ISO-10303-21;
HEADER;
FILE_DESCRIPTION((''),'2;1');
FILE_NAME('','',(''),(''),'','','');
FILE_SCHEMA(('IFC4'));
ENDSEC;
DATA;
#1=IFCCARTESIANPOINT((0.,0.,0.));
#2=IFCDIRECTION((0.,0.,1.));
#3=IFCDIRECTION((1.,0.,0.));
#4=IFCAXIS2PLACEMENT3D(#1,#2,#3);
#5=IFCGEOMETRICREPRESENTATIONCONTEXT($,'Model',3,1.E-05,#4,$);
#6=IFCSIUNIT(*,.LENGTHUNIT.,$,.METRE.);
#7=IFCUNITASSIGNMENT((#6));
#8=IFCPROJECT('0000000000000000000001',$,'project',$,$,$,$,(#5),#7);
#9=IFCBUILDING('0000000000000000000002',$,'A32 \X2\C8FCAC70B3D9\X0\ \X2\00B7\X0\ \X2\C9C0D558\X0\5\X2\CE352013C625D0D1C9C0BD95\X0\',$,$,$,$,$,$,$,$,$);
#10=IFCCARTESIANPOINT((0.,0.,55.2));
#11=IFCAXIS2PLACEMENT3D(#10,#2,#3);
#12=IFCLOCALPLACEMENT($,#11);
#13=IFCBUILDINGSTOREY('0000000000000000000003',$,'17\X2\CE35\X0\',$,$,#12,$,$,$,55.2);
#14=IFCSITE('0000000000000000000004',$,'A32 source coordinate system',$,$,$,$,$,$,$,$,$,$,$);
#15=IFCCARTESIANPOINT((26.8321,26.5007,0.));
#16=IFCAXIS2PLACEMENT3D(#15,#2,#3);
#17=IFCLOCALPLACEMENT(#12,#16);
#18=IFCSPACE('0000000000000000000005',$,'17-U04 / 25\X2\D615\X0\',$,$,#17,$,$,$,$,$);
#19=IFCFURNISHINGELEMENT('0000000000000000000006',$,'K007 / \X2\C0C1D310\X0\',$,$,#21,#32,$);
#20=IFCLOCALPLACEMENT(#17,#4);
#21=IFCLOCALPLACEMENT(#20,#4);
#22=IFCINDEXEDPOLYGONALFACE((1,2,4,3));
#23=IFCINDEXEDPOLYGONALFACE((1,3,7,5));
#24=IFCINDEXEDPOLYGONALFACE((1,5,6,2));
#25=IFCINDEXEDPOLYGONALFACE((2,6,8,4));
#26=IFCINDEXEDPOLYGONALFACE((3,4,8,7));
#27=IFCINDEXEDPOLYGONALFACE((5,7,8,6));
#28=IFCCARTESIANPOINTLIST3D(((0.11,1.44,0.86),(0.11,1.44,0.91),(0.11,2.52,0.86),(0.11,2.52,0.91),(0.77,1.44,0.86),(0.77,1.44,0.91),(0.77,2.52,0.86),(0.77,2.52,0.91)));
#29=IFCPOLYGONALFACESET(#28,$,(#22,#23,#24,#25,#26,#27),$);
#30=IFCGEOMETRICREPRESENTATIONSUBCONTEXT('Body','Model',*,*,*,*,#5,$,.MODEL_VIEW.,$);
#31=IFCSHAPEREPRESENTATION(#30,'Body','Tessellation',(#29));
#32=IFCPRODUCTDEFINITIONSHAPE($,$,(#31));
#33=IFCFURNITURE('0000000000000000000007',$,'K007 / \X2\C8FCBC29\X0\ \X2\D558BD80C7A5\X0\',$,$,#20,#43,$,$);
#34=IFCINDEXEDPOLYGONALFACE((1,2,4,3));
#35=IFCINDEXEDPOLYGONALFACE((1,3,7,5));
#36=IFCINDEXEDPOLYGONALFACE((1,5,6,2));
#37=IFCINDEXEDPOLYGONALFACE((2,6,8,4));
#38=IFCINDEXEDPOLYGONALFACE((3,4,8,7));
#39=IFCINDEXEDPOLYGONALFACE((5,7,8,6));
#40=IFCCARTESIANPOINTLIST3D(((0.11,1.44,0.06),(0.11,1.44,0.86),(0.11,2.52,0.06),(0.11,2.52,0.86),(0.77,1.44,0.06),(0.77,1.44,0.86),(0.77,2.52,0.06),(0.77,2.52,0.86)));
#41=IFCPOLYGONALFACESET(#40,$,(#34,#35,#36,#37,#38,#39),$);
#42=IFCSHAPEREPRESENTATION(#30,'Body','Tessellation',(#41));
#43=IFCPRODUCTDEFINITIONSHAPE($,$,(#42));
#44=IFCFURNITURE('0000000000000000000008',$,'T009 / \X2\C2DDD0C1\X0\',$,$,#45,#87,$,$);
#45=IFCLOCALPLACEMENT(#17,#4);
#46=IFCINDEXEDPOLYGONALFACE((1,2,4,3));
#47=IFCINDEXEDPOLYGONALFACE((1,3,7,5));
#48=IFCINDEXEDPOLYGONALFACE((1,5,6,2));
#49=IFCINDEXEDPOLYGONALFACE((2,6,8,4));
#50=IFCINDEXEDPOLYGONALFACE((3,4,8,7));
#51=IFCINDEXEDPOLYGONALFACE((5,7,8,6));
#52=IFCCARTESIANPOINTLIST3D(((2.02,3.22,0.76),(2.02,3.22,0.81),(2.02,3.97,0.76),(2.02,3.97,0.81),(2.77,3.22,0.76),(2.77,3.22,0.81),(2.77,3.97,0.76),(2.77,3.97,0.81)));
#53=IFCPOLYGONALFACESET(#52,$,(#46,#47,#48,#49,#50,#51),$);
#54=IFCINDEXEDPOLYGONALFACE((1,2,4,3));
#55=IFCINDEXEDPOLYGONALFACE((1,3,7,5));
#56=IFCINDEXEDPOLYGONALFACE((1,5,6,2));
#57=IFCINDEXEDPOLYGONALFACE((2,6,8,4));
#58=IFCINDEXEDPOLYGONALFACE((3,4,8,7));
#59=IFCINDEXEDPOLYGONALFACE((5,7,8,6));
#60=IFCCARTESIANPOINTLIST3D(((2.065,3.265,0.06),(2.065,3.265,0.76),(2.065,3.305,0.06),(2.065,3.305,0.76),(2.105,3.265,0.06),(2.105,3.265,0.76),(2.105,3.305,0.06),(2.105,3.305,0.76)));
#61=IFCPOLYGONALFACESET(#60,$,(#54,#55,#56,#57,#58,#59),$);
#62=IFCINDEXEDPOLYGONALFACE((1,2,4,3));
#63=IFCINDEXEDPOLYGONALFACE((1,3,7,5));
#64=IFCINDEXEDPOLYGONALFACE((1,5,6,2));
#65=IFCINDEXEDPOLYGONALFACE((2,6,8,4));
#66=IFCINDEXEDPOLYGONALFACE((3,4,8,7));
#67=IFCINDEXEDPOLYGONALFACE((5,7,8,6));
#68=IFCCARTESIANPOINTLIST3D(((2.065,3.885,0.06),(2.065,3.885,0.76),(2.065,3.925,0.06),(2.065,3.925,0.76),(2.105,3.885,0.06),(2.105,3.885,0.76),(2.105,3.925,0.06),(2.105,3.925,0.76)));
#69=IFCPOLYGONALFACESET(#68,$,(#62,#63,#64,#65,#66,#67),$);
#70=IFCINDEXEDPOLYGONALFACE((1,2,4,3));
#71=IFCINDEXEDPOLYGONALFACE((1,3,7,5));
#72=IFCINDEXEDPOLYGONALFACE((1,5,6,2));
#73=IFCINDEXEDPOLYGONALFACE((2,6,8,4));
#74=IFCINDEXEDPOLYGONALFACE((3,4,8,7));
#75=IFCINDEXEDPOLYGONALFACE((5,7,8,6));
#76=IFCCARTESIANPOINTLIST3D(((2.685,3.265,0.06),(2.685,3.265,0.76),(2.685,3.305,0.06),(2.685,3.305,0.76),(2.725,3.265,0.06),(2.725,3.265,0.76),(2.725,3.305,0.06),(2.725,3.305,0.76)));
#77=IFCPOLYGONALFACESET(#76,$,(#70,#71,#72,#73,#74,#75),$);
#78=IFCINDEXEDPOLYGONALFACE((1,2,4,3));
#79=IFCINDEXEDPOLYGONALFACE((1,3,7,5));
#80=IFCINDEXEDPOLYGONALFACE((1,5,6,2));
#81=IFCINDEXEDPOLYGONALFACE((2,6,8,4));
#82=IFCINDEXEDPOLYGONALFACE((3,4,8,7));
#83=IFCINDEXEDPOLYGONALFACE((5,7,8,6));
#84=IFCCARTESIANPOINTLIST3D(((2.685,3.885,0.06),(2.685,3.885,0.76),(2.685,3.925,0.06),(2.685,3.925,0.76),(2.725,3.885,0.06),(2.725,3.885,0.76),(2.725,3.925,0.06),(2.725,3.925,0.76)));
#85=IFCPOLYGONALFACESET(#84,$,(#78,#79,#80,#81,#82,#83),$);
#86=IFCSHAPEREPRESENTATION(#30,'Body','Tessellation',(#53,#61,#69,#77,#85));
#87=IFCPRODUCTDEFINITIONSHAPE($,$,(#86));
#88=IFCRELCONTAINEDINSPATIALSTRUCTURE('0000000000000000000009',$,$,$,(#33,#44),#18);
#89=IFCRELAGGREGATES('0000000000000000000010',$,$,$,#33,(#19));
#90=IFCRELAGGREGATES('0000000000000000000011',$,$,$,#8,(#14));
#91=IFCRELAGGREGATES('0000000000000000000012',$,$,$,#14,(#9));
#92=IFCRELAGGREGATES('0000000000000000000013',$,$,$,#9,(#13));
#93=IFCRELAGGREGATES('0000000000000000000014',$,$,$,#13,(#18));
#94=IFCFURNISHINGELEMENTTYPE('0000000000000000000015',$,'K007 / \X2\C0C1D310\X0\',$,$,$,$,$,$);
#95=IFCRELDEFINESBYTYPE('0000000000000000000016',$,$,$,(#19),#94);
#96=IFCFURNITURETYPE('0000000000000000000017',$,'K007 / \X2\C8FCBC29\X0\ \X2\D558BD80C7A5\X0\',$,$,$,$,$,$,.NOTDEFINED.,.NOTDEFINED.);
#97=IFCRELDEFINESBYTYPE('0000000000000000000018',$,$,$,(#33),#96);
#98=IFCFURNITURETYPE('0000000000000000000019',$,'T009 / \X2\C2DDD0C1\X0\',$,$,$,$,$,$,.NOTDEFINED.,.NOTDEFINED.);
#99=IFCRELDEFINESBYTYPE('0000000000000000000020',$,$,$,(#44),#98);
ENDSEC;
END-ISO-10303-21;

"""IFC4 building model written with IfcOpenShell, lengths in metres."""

from ifc_helpers import new_model, si_unit, frame, origin, origin_with_axes, place, context, subcontext, project, spatial, polyline, outline, extrude, source, transform, mapped, type_object, type_shapes, element, aggregate, save


model = new_model("IFC4")

# Units and contexts
model_context = context("Model", 3, precision=1e-05, world=origin_with_axes())
body_context = subcontext(model_context, "Body", "Model", "MODEL_VIEW")
ifc_project = project(units=[si_unit("LENGTHUNIT", "METRE")], contexts=[model_context])

# Site, building, storey
site = spatial("IfcSite", under=ifc_project, Name="A32 source coordinate system")
building = spatial("IfcBuilding", under=site, Name="A32 주거동 · 지하5층–옥탑지붕")
storey_placement = place(None, frame((0.0, 0.0, 55.2), z_axis=(0.0, 0.0, 1.0), x_axis=(1.0, 0.0, 0.0)))
storey = spatial("IfcBuildingStorey", under=building, at=storey_placement, Name="17층", Elevation=55.2)

# Shared definitions
space_1_placement = place(storey_placement, frame((26.8321, 26.5007, 0.0), z_axis=(0.0, 0.0, 1.0), x_axis=(1.0, 0.0, 0.0)))
space_1 = spatial("IfcSpace", under=storey, at=space_1_placement, Name="17-U04 / 25형")

# Furnishing element
furnishing_element_type_1 = type_object("IfcFurnishingElementType", Name="K007 / 상판")
shared_shape_1 = source(origin(), body_context, "Body", "SweptSolid", [
    extrude(outline(polyline([(0.77, 2.52), (0.77, 1.44), (0.11, 1.44), (0.11, 2.52), (0.77, 2.52)])), frame((0.0, 0.0, 0.86)), (0.0, 0.0, 1.0), 0.05),
])
type_shapes(furnishing_element_type_1, [shared_shape_1])
furniture_1_placement = place(space_1_placement, origin_with_axes())
furnishing_1_placement = place(furniture_1_placement, origin_with_axes())
furnishing_1 = element("IfcFurnishingElement", 1, at=furnishing_1_placement, type_object=furnishing_element_type_1, Name="K007 / 상판", context=body_context, shape_type="MappedRepresentation", body=[
    mapped(shared_shape_1, transform((0.0, 0.0, 0.0), scale=1.0)),
])

# Furniture
furniture_type_1 = type_object("IfcFurnitureType", Name="K007 / 주방 하부장", AssemblyPlace="NOTDEFINED", PredefinedType="NOTDEFINED")
shared_shape_2 = source(origin(), body_context, "Body", "SweptSolid", [
    extrude(outline(polyline([(0.11, 2.52), (0.77, 2.52), (0.77, 1.44), (0.11, 1.44), (0.11, 2.52)])), frame((0.0, 0.0, 0.06)), (0.0, 0.0, 1.0), 0.8),
])
type_shapes(furniture_type_1, [shared_shape_2])
furniture_1 = element("IfcFurniture", 2, at=furniture_1_placement, inside=space_1, type_object=furniture_type_1, Name="K007 / 주방 하부장", context=body_context, shape_type="MappedRepresentation", body=[
    mapped(shared_shape_2, transform((0.0, 0.0, 0.0), scale=1.0)),
])
aggregate(furniture_1, [furnishing_1])
furniture_type_2 = type_object("IfcFurnitureType", Name="T009 / 식탁", AssemblyPlace="NOTDEFINED", PredefinedType="NOTDEFINED")
shared_shape_3 = source(origin(), body_context, "Body", "SweptSolid", [
    extrude(outline(polyline([(2.77, 3.22), (2.02, 3.22), (2.02, 3.97), (2.77, 3.97), (2.77, 3.22)])), frame((0.0, 0.0, 0.76)), (0.0, 0.0, 1.0), 0.05),
    extrude(outline(polyline([(2.065, 3.265), (2.065, 3.305), (2.105, 3.305), (2.105, 3.265), (2.065, 3.265)])), frame((0.0, 0.0, 0.06)), (0.0, 0.0, 1.0), 0.7),
    extrude(outline(polyline([(2.065, 3.885), (2.065, 3.925), (2.105, 3.925), (2.105, 3.885), (2.065, 3.885)])), frame((0.0, 0.0, 0.06)), (0.0, 0.0, 1.0), 0.7),
    extrude(outline(polyline([(2.685, 3.265), (2.685, 3.305), (2.725, 3.305), (2.725, 3.265), (2.685, 3.265)])), frame((0.0, 0.0, 0.06)), (0.0, 0.0, 1.0), 0.7),
    extrude(outline(polyline([(2.685, 3.885), (2.685, 3.925), (2.725, 3.925), (2.725, 3.885), (2.685, 3.885)])), frame((0.0, 0.0, 0.06)), (0.0, 0.0, 1.0), 0.7),
])
type_shapes(furniture_type_2, [shared_shape_3])
furniture_2_placement = place(space_1_placement, origin_with_axes())
element("IfcFurniture", 3, at=furniture_2_placement, inside=space_1, type_object=furniture_type_2, Name="T009 / 식탁", context=body_context, shape_type="MappedRepresentation", body=[
    mapped(shared_shape_3, transform((0.0, 0.0, 0.0), scale=1.0)),
])

save(model, "model.ifc")
